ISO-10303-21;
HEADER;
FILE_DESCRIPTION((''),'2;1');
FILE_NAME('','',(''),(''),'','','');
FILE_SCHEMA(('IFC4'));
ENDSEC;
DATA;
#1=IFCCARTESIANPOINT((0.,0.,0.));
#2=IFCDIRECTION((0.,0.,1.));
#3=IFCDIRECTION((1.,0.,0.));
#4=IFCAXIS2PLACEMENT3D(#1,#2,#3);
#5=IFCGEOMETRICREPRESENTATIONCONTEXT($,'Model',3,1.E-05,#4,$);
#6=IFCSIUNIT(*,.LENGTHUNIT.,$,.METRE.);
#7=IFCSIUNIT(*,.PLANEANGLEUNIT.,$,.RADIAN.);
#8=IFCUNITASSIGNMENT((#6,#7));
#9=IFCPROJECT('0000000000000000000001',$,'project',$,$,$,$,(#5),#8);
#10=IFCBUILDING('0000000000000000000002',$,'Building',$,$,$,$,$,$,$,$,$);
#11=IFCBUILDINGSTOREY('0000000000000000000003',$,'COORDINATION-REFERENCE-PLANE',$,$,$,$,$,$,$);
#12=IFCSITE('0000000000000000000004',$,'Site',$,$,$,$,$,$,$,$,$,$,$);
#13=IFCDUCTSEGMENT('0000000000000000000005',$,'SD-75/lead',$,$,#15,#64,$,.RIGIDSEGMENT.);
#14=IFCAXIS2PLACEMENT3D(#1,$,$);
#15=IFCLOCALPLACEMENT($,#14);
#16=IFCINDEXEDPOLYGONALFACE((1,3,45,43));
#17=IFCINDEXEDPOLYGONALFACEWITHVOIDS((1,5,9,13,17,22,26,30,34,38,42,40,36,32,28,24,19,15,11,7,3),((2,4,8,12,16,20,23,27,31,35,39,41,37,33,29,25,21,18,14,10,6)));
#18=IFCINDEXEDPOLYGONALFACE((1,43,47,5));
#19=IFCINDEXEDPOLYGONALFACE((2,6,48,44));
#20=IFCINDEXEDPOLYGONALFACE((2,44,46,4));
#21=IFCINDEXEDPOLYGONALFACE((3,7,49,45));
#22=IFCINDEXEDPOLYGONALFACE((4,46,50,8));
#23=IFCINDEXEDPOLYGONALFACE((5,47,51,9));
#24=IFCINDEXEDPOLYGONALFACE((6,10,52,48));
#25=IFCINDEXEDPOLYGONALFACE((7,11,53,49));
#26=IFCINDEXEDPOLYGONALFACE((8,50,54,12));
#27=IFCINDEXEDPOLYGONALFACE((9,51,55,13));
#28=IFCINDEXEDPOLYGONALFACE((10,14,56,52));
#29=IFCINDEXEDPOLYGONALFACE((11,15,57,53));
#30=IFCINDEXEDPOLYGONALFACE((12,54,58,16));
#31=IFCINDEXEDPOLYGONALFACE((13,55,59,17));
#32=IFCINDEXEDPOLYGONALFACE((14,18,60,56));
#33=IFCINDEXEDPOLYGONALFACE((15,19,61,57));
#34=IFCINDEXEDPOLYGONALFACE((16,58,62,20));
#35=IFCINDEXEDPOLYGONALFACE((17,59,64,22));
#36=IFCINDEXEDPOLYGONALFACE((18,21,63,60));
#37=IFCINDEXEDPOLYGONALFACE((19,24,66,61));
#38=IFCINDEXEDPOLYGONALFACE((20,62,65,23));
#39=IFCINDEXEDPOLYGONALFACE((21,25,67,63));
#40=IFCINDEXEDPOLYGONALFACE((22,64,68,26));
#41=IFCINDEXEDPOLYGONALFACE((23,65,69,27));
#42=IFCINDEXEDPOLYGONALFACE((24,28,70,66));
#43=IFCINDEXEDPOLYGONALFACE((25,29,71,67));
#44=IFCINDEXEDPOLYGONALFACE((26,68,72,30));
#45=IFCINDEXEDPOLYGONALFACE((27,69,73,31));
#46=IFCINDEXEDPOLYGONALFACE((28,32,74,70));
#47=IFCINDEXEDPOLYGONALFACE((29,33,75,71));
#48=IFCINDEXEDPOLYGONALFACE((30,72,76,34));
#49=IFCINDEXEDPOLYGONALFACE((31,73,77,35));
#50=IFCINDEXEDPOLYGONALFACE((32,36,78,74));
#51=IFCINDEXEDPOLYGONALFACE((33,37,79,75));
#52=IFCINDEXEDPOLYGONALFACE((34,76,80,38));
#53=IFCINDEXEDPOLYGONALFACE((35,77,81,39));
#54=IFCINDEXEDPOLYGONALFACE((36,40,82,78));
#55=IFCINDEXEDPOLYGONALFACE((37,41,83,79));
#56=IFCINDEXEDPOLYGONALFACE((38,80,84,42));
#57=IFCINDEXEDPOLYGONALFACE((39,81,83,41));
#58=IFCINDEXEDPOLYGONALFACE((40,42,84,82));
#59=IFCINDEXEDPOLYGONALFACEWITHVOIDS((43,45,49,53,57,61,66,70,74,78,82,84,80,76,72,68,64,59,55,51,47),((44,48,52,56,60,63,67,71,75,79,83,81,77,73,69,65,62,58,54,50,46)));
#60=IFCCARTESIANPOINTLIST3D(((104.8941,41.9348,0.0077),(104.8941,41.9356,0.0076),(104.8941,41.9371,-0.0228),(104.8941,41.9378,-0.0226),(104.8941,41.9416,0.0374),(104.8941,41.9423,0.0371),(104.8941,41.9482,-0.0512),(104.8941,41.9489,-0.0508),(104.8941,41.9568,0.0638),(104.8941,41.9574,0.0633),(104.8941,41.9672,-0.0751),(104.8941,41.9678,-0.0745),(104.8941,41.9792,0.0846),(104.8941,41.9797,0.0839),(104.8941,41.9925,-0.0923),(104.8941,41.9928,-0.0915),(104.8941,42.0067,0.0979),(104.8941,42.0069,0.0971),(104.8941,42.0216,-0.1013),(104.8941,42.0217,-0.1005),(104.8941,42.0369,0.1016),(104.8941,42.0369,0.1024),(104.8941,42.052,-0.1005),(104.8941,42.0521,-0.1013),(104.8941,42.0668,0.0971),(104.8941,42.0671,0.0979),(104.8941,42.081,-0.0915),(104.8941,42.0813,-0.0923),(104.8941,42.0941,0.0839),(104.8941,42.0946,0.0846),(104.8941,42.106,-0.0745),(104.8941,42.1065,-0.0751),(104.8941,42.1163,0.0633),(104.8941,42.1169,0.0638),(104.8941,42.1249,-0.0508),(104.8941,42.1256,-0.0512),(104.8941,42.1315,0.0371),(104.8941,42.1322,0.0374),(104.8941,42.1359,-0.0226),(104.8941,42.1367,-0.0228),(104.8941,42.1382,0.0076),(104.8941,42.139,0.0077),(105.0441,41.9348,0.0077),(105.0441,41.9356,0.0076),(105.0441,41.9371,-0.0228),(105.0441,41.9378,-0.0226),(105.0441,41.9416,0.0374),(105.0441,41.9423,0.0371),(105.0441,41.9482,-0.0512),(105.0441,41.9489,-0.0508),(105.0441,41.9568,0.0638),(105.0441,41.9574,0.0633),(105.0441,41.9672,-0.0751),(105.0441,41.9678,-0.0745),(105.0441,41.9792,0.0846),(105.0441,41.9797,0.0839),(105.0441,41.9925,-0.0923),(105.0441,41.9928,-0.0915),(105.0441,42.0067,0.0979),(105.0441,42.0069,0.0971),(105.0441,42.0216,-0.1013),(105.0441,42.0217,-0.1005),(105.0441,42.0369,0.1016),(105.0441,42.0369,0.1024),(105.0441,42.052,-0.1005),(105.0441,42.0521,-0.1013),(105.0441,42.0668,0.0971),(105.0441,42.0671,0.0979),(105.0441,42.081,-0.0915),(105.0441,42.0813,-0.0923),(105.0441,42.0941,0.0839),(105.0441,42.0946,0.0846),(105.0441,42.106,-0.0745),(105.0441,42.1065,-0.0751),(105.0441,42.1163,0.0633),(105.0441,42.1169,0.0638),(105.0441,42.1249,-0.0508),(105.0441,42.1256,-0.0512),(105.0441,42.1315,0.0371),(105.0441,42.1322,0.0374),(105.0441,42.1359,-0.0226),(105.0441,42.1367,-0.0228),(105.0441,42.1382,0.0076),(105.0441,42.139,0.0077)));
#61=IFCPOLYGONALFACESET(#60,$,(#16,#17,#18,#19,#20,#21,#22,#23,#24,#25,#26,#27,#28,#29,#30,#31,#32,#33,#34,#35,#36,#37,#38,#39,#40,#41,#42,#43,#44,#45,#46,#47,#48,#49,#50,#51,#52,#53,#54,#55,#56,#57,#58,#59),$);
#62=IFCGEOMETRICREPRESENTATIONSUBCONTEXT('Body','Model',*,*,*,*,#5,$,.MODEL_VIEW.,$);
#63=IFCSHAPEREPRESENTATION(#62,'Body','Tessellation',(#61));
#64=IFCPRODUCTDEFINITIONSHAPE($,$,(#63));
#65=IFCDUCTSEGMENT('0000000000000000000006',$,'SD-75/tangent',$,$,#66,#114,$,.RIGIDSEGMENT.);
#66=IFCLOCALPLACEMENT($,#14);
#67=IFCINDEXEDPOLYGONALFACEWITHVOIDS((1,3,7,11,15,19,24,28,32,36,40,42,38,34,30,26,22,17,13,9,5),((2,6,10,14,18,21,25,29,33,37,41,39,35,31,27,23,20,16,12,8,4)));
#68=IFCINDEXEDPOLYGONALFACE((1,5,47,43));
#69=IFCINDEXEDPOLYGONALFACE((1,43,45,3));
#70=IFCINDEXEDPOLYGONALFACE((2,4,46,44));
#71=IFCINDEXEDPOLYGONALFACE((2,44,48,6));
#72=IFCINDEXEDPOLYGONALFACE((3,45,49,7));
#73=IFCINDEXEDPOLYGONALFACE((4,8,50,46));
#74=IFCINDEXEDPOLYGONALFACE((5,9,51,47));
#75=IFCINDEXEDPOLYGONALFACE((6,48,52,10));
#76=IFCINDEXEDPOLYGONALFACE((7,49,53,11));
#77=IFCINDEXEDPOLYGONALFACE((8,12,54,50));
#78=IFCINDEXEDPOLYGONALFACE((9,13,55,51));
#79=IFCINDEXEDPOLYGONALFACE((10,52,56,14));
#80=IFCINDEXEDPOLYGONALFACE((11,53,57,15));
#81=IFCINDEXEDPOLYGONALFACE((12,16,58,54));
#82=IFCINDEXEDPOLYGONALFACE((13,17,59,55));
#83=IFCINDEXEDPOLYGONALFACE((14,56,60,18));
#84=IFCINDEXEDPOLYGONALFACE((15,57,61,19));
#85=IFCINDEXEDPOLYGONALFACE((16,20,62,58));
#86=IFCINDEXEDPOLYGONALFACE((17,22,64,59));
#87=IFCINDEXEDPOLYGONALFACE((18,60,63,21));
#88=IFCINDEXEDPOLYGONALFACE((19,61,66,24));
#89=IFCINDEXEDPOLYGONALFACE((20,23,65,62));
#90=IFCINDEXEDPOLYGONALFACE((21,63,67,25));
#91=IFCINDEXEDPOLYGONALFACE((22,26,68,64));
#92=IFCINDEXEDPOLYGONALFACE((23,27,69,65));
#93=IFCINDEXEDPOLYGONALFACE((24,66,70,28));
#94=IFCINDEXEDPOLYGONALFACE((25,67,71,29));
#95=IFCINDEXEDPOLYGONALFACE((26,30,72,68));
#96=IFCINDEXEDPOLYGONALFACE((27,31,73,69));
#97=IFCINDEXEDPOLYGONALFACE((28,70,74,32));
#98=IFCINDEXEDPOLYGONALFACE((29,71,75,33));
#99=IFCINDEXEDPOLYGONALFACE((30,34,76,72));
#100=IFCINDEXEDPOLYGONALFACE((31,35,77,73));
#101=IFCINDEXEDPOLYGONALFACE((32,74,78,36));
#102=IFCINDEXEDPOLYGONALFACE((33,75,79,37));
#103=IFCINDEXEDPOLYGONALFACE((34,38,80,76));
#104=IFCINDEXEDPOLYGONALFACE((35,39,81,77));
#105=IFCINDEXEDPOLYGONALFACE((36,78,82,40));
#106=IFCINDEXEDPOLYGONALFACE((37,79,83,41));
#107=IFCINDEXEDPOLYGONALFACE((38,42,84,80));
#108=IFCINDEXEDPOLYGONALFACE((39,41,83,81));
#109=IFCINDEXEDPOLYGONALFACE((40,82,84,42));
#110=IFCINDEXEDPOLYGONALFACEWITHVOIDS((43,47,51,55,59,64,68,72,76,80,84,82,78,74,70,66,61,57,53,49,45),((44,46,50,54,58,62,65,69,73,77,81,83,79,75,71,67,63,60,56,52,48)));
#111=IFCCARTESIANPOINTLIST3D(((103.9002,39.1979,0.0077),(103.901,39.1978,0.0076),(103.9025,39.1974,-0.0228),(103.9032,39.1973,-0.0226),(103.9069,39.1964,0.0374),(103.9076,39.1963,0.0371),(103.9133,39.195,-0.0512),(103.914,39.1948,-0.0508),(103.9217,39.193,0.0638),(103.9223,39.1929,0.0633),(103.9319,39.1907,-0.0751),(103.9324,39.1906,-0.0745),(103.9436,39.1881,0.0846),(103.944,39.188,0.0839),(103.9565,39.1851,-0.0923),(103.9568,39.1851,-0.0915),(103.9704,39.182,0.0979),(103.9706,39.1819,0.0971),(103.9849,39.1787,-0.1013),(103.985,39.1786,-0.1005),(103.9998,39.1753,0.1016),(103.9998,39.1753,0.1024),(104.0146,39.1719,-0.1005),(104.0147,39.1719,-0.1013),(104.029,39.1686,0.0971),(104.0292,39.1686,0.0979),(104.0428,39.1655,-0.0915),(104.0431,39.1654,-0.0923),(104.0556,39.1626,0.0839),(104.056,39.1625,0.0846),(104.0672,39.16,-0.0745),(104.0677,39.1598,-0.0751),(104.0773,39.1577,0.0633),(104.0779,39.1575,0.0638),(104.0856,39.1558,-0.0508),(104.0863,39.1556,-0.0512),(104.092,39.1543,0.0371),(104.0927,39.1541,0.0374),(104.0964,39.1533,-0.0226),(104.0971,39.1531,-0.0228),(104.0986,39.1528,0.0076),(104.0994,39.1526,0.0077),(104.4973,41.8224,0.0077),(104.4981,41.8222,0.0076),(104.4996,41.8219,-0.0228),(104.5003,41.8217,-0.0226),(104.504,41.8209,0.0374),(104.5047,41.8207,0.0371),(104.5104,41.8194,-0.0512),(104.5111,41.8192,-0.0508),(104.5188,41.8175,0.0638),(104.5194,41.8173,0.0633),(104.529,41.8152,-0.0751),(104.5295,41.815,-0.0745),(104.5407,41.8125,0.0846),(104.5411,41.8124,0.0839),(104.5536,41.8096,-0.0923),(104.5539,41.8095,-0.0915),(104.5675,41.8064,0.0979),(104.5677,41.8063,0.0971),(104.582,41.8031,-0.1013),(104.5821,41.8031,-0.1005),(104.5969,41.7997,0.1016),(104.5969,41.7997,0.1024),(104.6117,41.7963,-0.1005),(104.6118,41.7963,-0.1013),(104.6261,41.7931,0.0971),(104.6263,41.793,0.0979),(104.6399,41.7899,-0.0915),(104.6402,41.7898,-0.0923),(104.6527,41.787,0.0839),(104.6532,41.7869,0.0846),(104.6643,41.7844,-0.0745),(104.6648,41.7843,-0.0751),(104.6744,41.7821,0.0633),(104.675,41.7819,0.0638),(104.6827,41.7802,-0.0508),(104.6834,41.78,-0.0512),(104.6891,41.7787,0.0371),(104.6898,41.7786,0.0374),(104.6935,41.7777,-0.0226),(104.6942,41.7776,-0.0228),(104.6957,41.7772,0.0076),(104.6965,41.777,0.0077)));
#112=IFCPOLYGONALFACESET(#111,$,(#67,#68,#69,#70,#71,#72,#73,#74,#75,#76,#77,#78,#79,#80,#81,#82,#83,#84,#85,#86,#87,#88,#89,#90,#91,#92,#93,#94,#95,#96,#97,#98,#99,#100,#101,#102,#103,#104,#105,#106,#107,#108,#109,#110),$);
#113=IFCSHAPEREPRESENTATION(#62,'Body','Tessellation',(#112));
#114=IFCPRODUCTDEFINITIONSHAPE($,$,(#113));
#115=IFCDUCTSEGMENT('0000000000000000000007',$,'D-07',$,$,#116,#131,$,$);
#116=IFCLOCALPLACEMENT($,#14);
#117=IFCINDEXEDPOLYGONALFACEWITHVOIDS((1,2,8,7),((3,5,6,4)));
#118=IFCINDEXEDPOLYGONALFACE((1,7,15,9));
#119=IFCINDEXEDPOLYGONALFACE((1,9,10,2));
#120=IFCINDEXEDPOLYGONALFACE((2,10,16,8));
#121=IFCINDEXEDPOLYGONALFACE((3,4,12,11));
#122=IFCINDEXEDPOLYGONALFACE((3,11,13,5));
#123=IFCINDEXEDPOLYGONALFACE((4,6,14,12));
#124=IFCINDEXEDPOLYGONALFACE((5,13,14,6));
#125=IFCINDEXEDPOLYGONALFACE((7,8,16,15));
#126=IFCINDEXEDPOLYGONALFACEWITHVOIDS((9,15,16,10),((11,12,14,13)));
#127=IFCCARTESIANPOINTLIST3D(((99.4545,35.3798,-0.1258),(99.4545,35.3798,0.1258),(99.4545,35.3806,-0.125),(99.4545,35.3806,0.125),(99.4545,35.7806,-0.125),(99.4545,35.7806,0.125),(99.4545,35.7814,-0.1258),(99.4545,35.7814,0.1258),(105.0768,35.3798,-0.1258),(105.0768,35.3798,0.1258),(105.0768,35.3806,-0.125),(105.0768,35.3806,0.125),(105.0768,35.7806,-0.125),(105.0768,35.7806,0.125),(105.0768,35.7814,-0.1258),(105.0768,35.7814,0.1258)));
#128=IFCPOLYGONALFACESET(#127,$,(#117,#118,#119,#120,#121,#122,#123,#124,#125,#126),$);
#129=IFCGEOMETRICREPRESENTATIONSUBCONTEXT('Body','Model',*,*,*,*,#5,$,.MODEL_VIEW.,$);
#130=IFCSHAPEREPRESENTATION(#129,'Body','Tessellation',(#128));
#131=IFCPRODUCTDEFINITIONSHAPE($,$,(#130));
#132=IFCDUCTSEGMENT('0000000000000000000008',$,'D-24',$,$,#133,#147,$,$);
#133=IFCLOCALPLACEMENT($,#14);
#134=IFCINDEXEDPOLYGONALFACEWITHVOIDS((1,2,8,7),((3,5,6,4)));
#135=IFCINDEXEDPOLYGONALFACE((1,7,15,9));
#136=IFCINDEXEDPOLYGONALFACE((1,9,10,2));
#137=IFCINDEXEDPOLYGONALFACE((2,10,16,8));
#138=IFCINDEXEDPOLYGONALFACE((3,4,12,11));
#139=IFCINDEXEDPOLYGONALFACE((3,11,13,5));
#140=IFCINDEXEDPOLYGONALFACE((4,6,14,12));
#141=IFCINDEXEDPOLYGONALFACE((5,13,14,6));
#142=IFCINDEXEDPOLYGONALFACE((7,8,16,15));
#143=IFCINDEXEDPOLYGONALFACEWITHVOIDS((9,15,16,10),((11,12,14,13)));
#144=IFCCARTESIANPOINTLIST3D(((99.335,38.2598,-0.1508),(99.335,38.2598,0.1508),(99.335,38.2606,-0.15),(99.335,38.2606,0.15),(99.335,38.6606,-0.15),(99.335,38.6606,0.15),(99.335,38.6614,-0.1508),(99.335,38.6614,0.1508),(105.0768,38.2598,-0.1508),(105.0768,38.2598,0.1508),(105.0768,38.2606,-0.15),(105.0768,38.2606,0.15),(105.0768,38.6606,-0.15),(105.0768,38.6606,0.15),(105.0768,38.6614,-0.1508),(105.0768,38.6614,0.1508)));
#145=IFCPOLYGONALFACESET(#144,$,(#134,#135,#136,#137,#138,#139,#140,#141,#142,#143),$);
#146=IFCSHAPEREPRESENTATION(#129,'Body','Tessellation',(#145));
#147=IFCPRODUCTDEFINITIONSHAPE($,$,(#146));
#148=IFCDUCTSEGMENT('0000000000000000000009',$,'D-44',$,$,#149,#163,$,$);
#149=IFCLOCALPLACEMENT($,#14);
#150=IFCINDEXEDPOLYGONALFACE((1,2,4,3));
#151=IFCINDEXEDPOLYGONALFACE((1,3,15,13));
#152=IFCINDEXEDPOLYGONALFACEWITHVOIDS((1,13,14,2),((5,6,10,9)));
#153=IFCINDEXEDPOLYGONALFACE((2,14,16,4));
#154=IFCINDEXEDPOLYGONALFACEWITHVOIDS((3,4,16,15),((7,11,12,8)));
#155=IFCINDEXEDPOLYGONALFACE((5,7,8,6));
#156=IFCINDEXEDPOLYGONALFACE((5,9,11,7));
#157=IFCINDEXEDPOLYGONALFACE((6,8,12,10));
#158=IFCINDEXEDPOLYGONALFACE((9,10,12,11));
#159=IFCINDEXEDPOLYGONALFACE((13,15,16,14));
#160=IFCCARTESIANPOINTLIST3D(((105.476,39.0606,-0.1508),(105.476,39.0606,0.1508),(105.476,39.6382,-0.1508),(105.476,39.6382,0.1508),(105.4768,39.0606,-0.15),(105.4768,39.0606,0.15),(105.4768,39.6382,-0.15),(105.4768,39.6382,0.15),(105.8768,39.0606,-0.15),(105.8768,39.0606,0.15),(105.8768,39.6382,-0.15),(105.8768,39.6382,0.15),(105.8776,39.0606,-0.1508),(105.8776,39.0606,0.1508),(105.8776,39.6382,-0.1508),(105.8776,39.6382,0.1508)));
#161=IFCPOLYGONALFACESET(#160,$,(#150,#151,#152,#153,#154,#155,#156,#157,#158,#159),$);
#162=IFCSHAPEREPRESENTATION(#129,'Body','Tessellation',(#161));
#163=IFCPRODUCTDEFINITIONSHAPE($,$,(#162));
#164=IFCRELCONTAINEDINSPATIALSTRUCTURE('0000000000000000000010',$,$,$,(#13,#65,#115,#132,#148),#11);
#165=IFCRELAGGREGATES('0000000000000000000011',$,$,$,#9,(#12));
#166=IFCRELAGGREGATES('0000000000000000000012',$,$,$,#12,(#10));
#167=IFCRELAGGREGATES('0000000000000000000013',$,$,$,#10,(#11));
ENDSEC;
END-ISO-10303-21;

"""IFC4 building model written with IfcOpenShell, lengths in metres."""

from ifc_helpers import new_model, si_unit, frame, origin, origin_with_axes, place, context, subcontext, project, spatial, hollow_rectangle, hollow_circle, extrude, element, save


model = new_model("IFC4")

# Units and contexts
model_context = context("Model", 3, precision=1e-05, world=origin_with_axes())
body_context_1 = subcontext(model_context, "Body", "Model", "MODEL_VIEW")
body_context_2 = subcontext(model_context, "Body", "Model", "MODEL_VIEW")
ifc_project = project(units=[si_unit("LENGTHUNIT", "METRE"), si_unit("PLANEANGLEUNIT", "RADIAN")], contexts=[model_context])

# Site, building, storey
site = spatial("IfcSite", under=ifc_project, Name="Site")
building = spatial("IfcBuilding", under=site, Name="Building")
storey = spatial("IfcBuildingStorey", under=building, Name="COORDINATION-REFERENCE-PLANE")

# Duct segment
duct_segment_1_placement = place(None, frame((105.0441, 42.0369, 0.0), z_axis=(-1.0, 0.0, 0.0), x_axis=(0.0, 0.0, 1.0)))
element("IfcDuctSegment", 1, at=duct_segment_1_placement, inside=storey, Name="SD-75/lead", PredefinedType="RIGIDSEGMENT", context=body_context_1, shape_type="SweptSolid", body=[
    extrude(hollow_circle(Radius=0.1024, WallThickness=0.0008), origin_with_axes(), (0.0, 0.0, 1.0), 0.15),
])

# Duct segment
duct_segment_2_placement = place(None, frame((104.5969, 41.7997, 0.0), z_axis=(-0.221849, -0.975081, 0.0), x_axis=(0.0, 0.0, 1.0)))
element("IfcDuctSegment", 2, at=duct_segment_2_placement, inside=storey, Name="SD-75/tangent", PredefinedType="RIGIDSEGMENT", context=body_context_1, shape_type="SweptSolid", body=[
    extrude(hollow_circle(Radius=0.1024, WallThickness=0.0008), origin_with_axes(), (0.0, 0.0, 1.0), 2.6915),
])

# Duct segments
duct_segment_3_placement = place(None, frame((99.4545, 35.5806, 0.0), z_axis=(1.0, 0.0, 0.0), x_axis=(0.0, 1.0, 0.0)))
element("IfcDuctSegment", 3, at=duct_segment_3_placement, inside=storey, Name="D-07", context=body_context_2, shape_type="SweptSolid", body=[
    extrude(hollow_rectangle(XDim=0.4016, YDim=0.2516, WallThickness=0.0008), origin(), (0.0, 0.0, 1.0), 5.6223),
])
duct_segment_4_placement = place(None, frame((99.335, 38.4606, 0.0), z_axis=(1.0, 0.0, 0.0), x_axis=(0.0, 1.0, 0.0)))
element("IfcDuctSegment", 4, at=duct_segment_4_placement, inside=storey, Name="D-24", context=body_context_2, shape_type="SweptSolid", body=[
    extrude(hollow_rectangle(XDim=0.4016, YDim=0.3016, WallThickness=0.0008), origin(), (0.0, 0.0, 1.0), 5.7417),
])
duct_segment_5_placement = place(None, frame((105.6768, 39.0606, 0.0), z_axis=(0.0, 1.0, 0.0), x_axis=(1.0, 0.0, 0.0)))
element("IfcDuctSegment", 5, at=duct_segment_5_placement, inside=storey, Name="D-44", context=body_context_2, shape_type="SweptSolid", body=[
    extrude(hollow_rectangle(XDim=0.4016, YDim=0.3016, WallThickness=0.0008), origin(), (0.0, 0.0, 1.0), 0.5776),
])

save(model, "model.ifc")
